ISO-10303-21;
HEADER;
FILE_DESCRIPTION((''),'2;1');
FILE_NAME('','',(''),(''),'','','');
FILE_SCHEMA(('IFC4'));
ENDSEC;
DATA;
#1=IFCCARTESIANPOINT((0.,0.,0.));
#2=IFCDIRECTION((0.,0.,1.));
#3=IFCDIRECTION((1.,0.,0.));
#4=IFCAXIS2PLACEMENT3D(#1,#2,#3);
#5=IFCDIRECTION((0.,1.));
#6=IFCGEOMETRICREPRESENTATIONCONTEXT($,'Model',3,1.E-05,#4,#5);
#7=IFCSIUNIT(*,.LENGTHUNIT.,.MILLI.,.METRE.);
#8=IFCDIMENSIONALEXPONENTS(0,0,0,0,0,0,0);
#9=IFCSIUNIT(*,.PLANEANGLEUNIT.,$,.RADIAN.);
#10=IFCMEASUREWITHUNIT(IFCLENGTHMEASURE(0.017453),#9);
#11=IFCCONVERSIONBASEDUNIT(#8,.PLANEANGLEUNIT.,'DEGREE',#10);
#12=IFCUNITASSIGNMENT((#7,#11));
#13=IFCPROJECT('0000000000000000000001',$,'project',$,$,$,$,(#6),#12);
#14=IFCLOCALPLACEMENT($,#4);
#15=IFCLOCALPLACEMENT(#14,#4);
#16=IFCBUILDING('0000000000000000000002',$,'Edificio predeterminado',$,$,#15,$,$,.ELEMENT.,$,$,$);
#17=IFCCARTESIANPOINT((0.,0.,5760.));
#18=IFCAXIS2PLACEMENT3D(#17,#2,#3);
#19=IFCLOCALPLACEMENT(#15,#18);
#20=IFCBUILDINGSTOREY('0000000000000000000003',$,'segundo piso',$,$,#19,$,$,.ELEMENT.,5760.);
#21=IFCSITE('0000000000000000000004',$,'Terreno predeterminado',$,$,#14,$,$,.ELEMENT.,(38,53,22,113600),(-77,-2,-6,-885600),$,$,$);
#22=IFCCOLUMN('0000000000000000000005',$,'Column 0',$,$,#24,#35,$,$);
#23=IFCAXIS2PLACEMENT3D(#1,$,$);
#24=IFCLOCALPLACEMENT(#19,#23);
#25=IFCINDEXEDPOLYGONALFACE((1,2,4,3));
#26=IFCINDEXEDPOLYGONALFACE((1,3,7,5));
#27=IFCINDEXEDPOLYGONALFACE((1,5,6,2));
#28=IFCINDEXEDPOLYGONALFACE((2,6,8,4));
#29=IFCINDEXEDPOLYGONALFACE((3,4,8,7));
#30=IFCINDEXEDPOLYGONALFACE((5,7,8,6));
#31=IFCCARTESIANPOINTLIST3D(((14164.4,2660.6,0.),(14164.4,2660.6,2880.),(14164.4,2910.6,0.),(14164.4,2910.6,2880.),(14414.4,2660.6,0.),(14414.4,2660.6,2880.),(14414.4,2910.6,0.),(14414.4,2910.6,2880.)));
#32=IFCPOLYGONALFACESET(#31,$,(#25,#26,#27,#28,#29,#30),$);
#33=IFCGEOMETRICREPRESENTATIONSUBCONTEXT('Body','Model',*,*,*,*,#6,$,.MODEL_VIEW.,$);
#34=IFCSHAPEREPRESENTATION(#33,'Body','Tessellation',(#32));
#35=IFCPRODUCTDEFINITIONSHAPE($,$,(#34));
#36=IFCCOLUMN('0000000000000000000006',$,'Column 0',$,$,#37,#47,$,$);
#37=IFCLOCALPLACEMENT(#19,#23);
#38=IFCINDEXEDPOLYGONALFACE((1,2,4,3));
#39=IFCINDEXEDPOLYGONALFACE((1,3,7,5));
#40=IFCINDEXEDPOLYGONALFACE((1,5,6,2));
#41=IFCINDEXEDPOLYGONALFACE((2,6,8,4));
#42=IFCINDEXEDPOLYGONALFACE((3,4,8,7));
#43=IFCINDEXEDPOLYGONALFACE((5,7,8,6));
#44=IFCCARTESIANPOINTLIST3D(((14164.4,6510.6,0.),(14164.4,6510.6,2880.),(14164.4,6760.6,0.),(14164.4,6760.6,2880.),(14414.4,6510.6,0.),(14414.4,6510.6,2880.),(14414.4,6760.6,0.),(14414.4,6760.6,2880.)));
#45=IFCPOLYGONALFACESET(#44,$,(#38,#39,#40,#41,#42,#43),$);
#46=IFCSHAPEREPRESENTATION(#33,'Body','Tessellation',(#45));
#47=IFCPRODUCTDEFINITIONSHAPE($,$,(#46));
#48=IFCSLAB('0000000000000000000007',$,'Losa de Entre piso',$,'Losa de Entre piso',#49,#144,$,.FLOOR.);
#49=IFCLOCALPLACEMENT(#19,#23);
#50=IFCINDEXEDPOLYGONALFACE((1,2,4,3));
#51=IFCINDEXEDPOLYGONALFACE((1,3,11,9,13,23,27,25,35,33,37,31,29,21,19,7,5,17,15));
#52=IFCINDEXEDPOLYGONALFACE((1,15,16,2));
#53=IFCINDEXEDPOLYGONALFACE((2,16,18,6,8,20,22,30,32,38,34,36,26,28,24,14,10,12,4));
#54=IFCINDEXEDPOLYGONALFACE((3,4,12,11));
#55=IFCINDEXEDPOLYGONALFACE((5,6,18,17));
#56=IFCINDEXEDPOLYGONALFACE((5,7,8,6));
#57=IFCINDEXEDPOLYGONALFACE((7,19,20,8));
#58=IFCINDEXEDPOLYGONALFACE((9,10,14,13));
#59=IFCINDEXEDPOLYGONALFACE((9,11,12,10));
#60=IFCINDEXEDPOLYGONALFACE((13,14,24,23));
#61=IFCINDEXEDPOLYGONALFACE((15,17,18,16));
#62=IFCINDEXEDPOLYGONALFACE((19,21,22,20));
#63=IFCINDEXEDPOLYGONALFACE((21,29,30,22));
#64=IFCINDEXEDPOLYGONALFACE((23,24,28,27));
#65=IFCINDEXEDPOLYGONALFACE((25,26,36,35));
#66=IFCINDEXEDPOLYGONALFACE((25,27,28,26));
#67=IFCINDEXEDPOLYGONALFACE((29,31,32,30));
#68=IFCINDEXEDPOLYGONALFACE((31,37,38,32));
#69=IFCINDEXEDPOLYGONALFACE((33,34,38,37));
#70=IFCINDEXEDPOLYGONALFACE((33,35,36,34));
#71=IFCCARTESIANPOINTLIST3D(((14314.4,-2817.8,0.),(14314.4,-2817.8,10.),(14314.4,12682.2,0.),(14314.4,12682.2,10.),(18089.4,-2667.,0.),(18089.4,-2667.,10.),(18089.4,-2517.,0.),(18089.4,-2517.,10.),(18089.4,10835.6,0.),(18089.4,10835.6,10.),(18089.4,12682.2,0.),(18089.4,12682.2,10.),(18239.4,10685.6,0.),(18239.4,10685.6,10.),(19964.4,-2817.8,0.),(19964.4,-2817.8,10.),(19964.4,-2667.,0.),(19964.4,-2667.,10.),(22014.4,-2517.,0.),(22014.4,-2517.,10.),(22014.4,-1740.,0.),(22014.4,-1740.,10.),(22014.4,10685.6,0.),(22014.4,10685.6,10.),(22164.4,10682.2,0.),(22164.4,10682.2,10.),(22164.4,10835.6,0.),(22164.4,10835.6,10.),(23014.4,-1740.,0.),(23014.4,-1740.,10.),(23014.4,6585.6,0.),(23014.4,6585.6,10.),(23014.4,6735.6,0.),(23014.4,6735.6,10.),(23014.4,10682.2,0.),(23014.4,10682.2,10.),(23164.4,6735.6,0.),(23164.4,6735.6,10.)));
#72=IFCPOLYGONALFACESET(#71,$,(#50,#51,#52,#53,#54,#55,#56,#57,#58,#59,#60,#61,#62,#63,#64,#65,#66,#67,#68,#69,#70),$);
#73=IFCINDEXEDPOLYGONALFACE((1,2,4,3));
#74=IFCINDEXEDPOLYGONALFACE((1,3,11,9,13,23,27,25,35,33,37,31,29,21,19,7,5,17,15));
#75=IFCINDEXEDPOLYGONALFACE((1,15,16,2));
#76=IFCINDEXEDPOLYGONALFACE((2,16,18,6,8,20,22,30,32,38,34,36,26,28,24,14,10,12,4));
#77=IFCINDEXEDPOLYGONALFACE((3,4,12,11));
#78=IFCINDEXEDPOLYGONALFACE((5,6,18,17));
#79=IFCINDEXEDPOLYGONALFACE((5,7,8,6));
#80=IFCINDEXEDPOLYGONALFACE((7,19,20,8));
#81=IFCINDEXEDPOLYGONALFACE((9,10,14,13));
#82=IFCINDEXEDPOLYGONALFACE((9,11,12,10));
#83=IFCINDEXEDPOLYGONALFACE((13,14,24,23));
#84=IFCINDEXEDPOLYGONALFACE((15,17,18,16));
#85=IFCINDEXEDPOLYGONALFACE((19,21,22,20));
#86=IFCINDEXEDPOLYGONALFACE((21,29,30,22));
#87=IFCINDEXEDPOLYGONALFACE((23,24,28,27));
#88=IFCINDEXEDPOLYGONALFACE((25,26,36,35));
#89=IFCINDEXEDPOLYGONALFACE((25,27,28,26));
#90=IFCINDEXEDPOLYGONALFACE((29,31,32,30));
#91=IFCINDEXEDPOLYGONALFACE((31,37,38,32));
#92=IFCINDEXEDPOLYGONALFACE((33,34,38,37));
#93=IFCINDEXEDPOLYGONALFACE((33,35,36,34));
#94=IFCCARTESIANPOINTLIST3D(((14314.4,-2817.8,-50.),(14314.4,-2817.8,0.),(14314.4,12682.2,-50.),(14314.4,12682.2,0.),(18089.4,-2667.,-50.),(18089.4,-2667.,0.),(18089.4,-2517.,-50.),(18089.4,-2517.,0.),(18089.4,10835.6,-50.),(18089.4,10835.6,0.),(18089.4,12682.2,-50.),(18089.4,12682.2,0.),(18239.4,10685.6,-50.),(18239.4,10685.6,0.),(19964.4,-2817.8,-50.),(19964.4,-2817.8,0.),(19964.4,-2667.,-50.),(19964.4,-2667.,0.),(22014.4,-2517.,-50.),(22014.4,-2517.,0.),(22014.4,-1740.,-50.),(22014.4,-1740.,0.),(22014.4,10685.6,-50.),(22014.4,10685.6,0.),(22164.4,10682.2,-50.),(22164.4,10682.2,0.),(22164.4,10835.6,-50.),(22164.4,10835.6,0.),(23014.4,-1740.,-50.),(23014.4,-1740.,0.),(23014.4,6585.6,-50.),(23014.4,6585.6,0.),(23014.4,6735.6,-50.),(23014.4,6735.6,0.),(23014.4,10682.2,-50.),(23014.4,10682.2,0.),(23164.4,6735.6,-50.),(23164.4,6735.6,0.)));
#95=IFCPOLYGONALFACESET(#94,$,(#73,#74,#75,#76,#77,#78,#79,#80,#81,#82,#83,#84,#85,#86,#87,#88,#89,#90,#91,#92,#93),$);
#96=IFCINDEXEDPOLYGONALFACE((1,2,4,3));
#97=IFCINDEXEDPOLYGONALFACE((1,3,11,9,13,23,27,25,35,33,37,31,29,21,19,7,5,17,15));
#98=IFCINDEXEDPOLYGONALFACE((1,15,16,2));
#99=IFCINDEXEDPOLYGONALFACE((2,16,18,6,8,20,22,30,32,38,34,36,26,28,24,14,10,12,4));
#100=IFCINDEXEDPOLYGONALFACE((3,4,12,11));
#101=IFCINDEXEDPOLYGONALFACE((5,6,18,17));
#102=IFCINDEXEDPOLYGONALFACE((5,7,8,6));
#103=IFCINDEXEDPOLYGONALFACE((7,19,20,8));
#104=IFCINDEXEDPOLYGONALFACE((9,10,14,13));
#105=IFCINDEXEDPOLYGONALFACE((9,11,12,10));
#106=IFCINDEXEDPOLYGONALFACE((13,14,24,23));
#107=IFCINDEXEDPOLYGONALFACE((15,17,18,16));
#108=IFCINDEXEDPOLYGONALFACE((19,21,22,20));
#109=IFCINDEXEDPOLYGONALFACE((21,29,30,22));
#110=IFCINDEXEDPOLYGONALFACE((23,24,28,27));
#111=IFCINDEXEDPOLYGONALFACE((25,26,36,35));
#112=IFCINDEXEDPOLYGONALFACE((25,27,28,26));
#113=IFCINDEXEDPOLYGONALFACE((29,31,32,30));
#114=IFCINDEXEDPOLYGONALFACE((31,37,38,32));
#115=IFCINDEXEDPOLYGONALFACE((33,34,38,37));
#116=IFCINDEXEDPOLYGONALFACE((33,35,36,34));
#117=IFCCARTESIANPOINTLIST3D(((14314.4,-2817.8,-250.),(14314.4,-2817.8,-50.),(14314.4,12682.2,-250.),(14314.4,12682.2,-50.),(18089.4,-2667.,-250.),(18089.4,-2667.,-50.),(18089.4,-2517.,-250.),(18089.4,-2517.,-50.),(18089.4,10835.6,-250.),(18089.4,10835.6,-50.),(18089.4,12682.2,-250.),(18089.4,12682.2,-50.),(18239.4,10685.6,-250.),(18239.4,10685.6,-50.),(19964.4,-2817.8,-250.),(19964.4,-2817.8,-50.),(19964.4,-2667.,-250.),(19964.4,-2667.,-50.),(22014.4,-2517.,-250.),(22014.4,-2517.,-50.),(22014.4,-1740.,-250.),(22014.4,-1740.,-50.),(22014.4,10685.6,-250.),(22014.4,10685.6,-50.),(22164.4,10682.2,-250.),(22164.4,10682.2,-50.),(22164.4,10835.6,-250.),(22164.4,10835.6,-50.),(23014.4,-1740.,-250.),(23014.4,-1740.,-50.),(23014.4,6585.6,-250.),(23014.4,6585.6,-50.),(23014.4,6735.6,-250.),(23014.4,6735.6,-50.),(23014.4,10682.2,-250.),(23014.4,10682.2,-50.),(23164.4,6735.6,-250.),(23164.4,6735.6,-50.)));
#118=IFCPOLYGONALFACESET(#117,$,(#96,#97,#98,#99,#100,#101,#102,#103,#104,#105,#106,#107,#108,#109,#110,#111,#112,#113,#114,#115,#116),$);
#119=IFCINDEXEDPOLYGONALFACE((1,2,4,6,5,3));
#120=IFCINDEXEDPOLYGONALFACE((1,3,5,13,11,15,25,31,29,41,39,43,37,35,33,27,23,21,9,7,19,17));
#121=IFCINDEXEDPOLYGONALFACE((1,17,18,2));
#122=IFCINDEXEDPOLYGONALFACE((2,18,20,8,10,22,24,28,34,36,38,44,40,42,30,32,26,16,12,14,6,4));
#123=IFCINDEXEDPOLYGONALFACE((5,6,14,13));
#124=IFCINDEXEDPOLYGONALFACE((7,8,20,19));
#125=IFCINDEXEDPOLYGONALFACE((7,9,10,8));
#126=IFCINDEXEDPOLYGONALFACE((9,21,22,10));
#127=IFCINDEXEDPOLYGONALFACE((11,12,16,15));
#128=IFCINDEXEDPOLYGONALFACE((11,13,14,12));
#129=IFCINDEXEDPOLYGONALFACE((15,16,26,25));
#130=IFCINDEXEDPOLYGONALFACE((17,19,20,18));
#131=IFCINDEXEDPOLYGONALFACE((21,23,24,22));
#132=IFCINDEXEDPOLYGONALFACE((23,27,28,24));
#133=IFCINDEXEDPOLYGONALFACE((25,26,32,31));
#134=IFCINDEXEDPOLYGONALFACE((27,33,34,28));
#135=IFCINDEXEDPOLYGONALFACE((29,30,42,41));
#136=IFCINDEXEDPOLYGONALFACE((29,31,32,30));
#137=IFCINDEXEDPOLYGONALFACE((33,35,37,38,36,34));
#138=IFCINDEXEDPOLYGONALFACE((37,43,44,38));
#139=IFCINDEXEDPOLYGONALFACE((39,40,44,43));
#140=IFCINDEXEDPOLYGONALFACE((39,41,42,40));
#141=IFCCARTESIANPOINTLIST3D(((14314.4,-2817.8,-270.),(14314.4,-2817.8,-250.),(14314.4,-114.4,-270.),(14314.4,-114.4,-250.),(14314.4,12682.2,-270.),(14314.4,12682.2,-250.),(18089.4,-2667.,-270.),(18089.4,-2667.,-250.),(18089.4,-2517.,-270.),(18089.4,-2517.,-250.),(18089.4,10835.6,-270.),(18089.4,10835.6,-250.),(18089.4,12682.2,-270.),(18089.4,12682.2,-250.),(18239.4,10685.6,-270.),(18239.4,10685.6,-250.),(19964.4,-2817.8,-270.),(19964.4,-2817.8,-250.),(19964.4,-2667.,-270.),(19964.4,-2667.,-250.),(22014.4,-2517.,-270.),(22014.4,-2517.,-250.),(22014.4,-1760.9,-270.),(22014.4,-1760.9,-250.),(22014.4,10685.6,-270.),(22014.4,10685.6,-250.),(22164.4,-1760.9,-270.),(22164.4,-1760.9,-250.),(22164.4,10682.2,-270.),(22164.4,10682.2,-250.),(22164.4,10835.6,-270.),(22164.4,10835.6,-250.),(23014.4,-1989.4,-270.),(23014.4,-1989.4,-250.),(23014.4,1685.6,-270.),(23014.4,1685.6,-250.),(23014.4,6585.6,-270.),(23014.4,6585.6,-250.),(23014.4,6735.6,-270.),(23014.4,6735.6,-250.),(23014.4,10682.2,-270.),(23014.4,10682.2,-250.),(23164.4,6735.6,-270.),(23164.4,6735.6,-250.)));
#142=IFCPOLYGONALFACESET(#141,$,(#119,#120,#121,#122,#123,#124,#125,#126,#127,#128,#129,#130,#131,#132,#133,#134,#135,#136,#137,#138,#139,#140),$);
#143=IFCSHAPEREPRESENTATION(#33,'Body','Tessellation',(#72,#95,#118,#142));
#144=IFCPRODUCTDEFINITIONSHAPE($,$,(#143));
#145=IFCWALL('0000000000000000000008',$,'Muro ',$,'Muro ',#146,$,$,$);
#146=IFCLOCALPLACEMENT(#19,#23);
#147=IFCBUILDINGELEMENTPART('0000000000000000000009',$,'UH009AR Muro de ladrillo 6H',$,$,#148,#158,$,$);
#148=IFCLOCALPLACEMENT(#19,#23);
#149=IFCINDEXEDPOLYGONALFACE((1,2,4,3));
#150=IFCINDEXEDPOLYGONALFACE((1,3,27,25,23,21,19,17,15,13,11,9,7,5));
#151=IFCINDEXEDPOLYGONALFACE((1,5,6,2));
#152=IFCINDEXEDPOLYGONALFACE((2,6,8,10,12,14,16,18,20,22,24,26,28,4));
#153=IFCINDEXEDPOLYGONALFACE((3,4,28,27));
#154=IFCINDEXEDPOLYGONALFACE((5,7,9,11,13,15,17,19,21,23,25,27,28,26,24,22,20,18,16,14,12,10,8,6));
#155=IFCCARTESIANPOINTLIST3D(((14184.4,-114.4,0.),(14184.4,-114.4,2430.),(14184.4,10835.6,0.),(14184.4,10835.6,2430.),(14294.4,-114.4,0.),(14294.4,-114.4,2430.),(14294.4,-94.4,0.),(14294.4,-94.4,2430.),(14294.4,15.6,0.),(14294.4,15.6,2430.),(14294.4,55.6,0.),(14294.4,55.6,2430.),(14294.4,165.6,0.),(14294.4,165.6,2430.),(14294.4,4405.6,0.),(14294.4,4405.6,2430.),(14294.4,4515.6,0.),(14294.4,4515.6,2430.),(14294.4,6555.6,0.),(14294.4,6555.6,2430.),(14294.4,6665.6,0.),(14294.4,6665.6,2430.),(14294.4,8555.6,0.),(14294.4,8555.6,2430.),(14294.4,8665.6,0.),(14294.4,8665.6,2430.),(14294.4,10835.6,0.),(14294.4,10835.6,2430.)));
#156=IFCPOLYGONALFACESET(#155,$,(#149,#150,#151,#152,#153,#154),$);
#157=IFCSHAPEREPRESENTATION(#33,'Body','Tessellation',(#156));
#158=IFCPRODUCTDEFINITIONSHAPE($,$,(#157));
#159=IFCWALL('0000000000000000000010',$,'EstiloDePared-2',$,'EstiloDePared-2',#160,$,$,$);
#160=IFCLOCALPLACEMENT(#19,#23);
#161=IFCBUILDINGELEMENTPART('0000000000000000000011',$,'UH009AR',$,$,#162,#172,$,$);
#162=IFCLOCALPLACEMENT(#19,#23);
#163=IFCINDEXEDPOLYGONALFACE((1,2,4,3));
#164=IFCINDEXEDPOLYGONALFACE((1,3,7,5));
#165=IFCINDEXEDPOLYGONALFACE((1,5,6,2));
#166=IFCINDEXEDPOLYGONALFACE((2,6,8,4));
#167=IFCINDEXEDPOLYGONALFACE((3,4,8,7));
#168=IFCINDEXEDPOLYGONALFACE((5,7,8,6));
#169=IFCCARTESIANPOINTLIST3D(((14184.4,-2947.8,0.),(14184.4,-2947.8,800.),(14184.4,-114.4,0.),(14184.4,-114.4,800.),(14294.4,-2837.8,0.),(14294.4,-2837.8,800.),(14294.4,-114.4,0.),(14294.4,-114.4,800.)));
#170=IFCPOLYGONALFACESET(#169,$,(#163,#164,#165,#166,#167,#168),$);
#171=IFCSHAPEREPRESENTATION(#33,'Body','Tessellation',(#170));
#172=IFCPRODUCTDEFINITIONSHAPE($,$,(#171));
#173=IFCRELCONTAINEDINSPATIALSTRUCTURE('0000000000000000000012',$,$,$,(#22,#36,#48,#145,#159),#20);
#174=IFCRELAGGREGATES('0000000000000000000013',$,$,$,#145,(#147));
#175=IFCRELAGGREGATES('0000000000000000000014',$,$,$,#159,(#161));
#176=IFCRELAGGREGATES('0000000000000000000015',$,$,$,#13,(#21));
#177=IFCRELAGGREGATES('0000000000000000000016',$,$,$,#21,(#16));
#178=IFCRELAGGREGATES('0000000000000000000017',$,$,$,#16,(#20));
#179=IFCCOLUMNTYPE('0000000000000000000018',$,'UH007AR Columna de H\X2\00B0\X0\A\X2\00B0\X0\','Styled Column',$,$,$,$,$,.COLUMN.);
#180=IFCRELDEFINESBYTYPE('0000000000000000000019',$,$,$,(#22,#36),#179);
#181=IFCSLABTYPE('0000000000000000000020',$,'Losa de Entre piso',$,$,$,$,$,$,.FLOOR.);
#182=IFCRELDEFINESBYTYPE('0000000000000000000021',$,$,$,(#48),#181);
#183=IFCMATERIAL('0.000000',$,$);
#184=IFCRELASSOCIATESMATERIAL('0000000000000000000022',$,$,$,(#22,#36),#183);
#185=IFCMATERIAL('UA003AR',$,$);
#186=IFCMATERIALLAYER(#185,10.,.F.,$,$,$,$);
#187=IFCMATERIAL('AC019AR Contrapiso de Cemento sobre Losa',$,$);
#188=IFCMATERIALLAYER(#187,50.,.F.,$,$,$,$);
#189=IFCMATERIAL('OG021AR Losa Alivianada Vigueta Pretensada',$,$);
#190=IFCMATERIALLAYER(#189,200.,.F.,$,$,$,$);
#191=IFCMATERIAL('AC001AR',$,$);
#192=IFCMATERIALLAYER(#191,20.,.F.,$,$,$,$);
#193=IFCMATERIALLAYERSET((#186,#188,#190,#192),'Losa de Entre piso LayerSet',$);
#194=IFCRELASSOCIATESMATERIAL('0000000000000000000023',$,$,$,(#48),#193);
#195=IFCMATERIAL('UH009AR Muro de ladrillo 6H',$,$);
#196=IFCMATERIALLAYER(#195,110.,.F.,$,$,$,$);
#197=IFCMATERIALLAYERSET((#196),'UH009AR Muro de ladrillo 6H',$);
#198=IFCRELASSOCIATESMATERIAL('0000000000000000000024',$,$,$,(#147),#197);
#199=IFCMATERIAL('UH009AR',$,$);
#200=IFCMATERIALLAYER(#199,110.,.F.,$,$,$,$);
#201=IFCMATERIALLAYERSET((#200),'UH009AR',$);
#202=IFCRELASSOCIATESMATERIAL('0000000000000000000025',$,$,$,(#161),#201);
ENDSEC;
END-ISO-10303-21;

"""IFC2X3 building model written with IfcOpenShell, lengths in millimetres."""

from ifc_helpers import new_model, entity, si_unit, converted_unit, direction, frame, origin_with_axes, place, context, subcontext, project, spatial, polyline, outline, extrude, material, layer, layer_set, layer_usage, type_object, element, aggregate, save


model = new_model("IFC2X3")

# Units and contexts
model_context = context("Model", 3, precision=1e-05, world=origin_with_axes(), true_north=direction((0.0, 1.0)))
body_context = subcontext(model_context, "Body", "Model", "MODEL_VIEW")
ifc_project = project(units=[si_unit("LENGTHUNIT", "METRE", prefix="MILLI"), converted_unit("PLANEANGLEUNIT", "DEGREE", entity("IfcLengthMeasure", 0.017453), si_unit("PLANEANGLEUNIT", "RADIAN"), dimensions=[0, 0, 0, 0, 0, 0, 0])], contexts=[model_context])

# Site, building, storey
site_placement = place(None, origin_with_axes())
site = spatial("IfcSite", under=ifc_project, at=site_placement, Name="Terreno predeterminado", CompositionType="ELEMENT", RefLatitude=(38, 53, 22, 113600), RefLongitude=(-77, -2, -6, -885600))
building_placement = place(site_placement, origin_with_axes())
building = spatial("IfcBuilding", under=site, at=building_placement, Name="Edificio predeterminado", CompositionType="ELEMENT")
storey_placement = place(building_placement, frame((0.0, 0.0, 5760.0), z_axis=(0.0, 0.0, 1.0), x_axis=(1.0, 0.0, 0.0)))
storey = spatial("IfcBuildingStorey", under=building, at=storey_placement, Name="segundo piso", CompositionType="ELEMENT", Elevation=5760.0)

# Columns
ifc_material_1 = material(Name="0.000000")
column_type = type_object("IfcColumnType", Name="UH007AR Columna de H°A°", Description="Styled Column", PredefinedType="COLUMN")
for number, where, z_axis, x_axis, name in (
    (1, (14289.4, 2785.6, 0.0), (0.0, 0.0, 1.0), (1.0, 0.0, 0.0), "Column 0"),
    (2, (14289.4, 6635.6, 0.0), (0.0, 0.0, 1.0), (1.0, 0.0, 0.0), "Column 0"),
):
    element("IfcColumn", number, at=place(storey_placement, frame(where, z_axis=z_axis, x_axis=x_axis)), inside=storey, type_object=column_type, material=ifc_material_1, Name=name, context=body_context, shape_type="SweptSolid", body=[
        extrude(outline(polyline([(-125.0, -125.0), (125.0, -125.0), (125.0, 125.0), (-125.0, 125.0), (-125.0, -125.0)])), origin_with_axes(), (0.0, 0.0, 1.0), 2880.0),
    ])

# Slab
ifc_material_2 = material(Name="UA003AR")
ifc_layer_1 = layer(ifc_material_2, 10.0, ventilated=False)
ifc_material_3 = material(Name="AC019AR Contrapiso de Cemento sobre Losa")
ifc_layer_2 = layer(ifc_material_3, 50.0, ventilated=False)
ifc_material_4 = material(Name="OG021AR Losa Alivianada Vigueta Pretensada")
ifc_layer_3 = layer(ifc_material_4, 200.0, ventilated=False)
ifc_material_5 = material(Name="AC001AR")
ifc_layer_4 = layer(ifc_material_5, 20.0, ventilated=False)
ifc_layer_set_1 = layer_set([ifc_layer_1, ifc_layer_2, ifc_layer_3, ifc_layer_4], Name="Losa de Entre piso LayerSet")
ifc_layer_usage_1 = layer_usage(ifc_layer_set_1, "AXIS3", "POSITIVE", 0.0)
slab_type = type_object("IfcSlabType", Name="Losa de Entre piso", PredefinedType="FLOOR")
slab_placement = place(storey_placement, frame((0.0, 0.0, -5760.0), z_axis=(0.0, 0.0, 1.0), x_axis=(1.0, 0.0, 0.0)))
element("IfcSlab", 3, at=slab_placement, inside=storey, type_object=slab_type, material=ifc_layer_usage_1, Name="Losa de Entre piso", ObjectType="Losa de Entre piso", PredefinedType="FLOOR", context=body_context, shape_type="SweptSolid", body=[
    extrude(outline(polyline([(0.0, -777.0), (-1000.0, -777.0), (-1000.0, -9102.6), (-1150.0, -9252.6), (-1000.0, -9252.6), (-1000.0, -13199.1), (-150.0, -13199.1), (-150.0, -13352.6), (0.0, -13202.6), (3775.0, -13202.6), (3925.0, -13352.6), (3925.0, -15199.1), (7700.0, -15199.1), (7700.0, 300.9), (2050.0, 300.9), (2050.0, 150.0), (3925.0, 150.0), (3925.0, 0.0), (0.0, 0.0), (0.0, -777.0)])), frame((22014.4, -2517.0, 5760.0), z_axis=(0.0, 0.0, 1.0), x_axis=(-1.0, 0.0, 0.0)), (0.0, 0.0, 1.0), 10.0),
    extrude(outline(polyline([(0.0, -777.0), (-1000.0, -777.0), (-1000.0, -9102.6), (-1150.0, -9252.6), (-1000.0, -9252.6), (-1000.0, -13199.1), (-150.0, -13199.1), (-150.0, -13352.6), (0.0, -13202.6), (3775.0, -13202.6), (3925.0, -13352.6), (3925.0, -15199.1), (7700.0, -15199.1), (7700.0, 300.9), (2050.0, 300.9), (2050.0, 150.0), (3925.0, 150.0), (3925.0, 0.0), (0.0, 0.0), (0.0, -777.0)])), frame((22014.4, -2517.0, 5710.0), z_axis=(0.0, 0.0, 1.0), x_axis=(-1.0, 0.0, 0.0)), (0.0, 0.0, 1.0), 50.0),
    extrude(outline(polyline([(0.0, -777.0), (-1000.0, -777.0), (-1000.0, -9102.6), (-1150.0, -9252.6), (-1000.0, -9252.6), (-1000.0, -13199.1), (-150.0, -13199.1), (-150.0, -13352.6), (0.0, -13202.6), (3775.0, -13202.6), (3925.0, -13352.6), (3925.0, -15199.1), (7700.0, -15199.1), (7700.0, 300.9), (2050.0, 300.9), (2050.0, 150.0), (3925.0, 150.0), (3925.0, 0.0), (0.0, 0.0), (0.0, -777.0)])), frame((22014.4, -2517.0, 5510.0), z_axis=(0.0, 0.0, 1.0), x_axis=(-1.0, 0.0, 0.0)), (0.0, 0.0, 1.0), 200.0),
    extrude(outline(polyline([(-1305.7, 1305.7), (-3975.1, -1363.6), (5073.5, -10412.1), (6985.1, -12323.8), (10980.3, -8328.6), (10873.6, -8221.9), (9547.8, -9547.8), (9441.7, -9441.7), (12217.1, -6666.3), (11682.5, -6131.7), (11788.6, -6025.7), (12551.1, -5586.1), (9952.5, -2987.5), (6487.7, 477.3), (6487.7, 689.4), (6381.6, 583.4), (3591.0, 3374.0), (2990.0, 2773.0), (2881.5, 2881.5), (2881.5, 2669.3), (212.1, 0.0), (0.0, 0.0), (-1305.7, 1305.7)])), frame((18089.4, 10835.6, 5490.0), z_axis=(0.0, 0.0, 1.0), x_axis=(0.707107, -0.707107, 0.0)), (0.0, 0.0, 1.0), 20.0),
])

# Walls, building element parts
wall_1_placement = place(storey_placement, frame((14239.4, 10835.6, 0.0), z_axis=(0.0, 0.0, 1.0), x_axis=(0.0, -1.0, 0.0)))
wall_1 = element("IfcWall", 4, at=wall_1_placement, inside=storey, Name="Muro ", ObjectType="Muro ")
ifc_material_6 = material(Name="UH009AR Muro de ladrillo 6H")
ifc_layer_5 = layer(ifc_material_6, 110.0, ventilated=False)
ifc_layer_set_2 = layer_set([ifc_layer_5], Name="UH009AR Muro de ladrillo 6H")
ifc_layer_usage_2 = layer_usage(ifc_layer_set_2, "AXIS2", "NEGATIVE", -55.0)
building_element_part_1_placement = place(wall_1_placement, origin_with_axes())
building_element_part_1 = element("IfcBuildingElementPart", 5, at=building_element_part_1_placement, material=ifc_layer_usage_2, Name="UH009AR Muro de ladrillo 6H", context=body_context, shape_type="SweptSolid", body=[
    extrude(outline(polyline([(4280.0, 55.0), (6320.0, 55.0), (6430.0, 55.0), (10670.0, 55.0), (10780.0, 55.0), (10820.0, 55.0), (10930.0, 55.0), (10950.0, 55.0), (10950.0, -55.0), (0.0, -55.0), (0.0, 55.0), (2170.0, 55.0), (2280.0, 55.0), (4170.0, 55.0), (4280.0, 55.0)])), origin_with_axes(), (0.0, 0.0, 1.0), 2430.0),
])
aggregate(wall_1, [building_element_part_1])
wall_2_placement = place(storey_placement, frame((14239.4, -2892.8, 0.0), z_axis=(0.0, 0.0, 1.0), x_axis=(0.0, 1.0, 0.0)))
wall_2 = element("IfcWall", 6, at=wall_2_placement, inside=storey, Name="EstiloDePared-2", ObjectType="EstiloDePared-2")
ifc_material_7 = material(Name="UH009AR")
ifc_layer_6 = layer(ifc_material_7, 110.0, ventilated=False)
ifc_layer_set_3 = layer_set([ifc_layer_6], Name="UH009AR")
ifc_layer_usage_3 = layer_usage(ifc_layer_set_3, "AXIS2", "NEGATIVE", -55.0)
building_element_part_2_placement = place(wall_2_placement, origin_with_axes())
building_element_part_2 = element("IfcBuildingElementPart", 7, at=building_element_part_2_placement, material=ifc_layer_usage_3, Name="UH009AR", context=body_context, shape_type="SweptSolid", body=[
    extrude(outline(polyline([(2778.4, 55.0), (2778.4, -55.0), (55.0, -55.0), (-55.0, 55.0), (2778.4, 55.0)])), origin_with_axes(), (0.0, 0.0, 1.0), 800.0),
])
aggregate(wall_2, [building_element_part_2])

save(model, "model.ifc")
